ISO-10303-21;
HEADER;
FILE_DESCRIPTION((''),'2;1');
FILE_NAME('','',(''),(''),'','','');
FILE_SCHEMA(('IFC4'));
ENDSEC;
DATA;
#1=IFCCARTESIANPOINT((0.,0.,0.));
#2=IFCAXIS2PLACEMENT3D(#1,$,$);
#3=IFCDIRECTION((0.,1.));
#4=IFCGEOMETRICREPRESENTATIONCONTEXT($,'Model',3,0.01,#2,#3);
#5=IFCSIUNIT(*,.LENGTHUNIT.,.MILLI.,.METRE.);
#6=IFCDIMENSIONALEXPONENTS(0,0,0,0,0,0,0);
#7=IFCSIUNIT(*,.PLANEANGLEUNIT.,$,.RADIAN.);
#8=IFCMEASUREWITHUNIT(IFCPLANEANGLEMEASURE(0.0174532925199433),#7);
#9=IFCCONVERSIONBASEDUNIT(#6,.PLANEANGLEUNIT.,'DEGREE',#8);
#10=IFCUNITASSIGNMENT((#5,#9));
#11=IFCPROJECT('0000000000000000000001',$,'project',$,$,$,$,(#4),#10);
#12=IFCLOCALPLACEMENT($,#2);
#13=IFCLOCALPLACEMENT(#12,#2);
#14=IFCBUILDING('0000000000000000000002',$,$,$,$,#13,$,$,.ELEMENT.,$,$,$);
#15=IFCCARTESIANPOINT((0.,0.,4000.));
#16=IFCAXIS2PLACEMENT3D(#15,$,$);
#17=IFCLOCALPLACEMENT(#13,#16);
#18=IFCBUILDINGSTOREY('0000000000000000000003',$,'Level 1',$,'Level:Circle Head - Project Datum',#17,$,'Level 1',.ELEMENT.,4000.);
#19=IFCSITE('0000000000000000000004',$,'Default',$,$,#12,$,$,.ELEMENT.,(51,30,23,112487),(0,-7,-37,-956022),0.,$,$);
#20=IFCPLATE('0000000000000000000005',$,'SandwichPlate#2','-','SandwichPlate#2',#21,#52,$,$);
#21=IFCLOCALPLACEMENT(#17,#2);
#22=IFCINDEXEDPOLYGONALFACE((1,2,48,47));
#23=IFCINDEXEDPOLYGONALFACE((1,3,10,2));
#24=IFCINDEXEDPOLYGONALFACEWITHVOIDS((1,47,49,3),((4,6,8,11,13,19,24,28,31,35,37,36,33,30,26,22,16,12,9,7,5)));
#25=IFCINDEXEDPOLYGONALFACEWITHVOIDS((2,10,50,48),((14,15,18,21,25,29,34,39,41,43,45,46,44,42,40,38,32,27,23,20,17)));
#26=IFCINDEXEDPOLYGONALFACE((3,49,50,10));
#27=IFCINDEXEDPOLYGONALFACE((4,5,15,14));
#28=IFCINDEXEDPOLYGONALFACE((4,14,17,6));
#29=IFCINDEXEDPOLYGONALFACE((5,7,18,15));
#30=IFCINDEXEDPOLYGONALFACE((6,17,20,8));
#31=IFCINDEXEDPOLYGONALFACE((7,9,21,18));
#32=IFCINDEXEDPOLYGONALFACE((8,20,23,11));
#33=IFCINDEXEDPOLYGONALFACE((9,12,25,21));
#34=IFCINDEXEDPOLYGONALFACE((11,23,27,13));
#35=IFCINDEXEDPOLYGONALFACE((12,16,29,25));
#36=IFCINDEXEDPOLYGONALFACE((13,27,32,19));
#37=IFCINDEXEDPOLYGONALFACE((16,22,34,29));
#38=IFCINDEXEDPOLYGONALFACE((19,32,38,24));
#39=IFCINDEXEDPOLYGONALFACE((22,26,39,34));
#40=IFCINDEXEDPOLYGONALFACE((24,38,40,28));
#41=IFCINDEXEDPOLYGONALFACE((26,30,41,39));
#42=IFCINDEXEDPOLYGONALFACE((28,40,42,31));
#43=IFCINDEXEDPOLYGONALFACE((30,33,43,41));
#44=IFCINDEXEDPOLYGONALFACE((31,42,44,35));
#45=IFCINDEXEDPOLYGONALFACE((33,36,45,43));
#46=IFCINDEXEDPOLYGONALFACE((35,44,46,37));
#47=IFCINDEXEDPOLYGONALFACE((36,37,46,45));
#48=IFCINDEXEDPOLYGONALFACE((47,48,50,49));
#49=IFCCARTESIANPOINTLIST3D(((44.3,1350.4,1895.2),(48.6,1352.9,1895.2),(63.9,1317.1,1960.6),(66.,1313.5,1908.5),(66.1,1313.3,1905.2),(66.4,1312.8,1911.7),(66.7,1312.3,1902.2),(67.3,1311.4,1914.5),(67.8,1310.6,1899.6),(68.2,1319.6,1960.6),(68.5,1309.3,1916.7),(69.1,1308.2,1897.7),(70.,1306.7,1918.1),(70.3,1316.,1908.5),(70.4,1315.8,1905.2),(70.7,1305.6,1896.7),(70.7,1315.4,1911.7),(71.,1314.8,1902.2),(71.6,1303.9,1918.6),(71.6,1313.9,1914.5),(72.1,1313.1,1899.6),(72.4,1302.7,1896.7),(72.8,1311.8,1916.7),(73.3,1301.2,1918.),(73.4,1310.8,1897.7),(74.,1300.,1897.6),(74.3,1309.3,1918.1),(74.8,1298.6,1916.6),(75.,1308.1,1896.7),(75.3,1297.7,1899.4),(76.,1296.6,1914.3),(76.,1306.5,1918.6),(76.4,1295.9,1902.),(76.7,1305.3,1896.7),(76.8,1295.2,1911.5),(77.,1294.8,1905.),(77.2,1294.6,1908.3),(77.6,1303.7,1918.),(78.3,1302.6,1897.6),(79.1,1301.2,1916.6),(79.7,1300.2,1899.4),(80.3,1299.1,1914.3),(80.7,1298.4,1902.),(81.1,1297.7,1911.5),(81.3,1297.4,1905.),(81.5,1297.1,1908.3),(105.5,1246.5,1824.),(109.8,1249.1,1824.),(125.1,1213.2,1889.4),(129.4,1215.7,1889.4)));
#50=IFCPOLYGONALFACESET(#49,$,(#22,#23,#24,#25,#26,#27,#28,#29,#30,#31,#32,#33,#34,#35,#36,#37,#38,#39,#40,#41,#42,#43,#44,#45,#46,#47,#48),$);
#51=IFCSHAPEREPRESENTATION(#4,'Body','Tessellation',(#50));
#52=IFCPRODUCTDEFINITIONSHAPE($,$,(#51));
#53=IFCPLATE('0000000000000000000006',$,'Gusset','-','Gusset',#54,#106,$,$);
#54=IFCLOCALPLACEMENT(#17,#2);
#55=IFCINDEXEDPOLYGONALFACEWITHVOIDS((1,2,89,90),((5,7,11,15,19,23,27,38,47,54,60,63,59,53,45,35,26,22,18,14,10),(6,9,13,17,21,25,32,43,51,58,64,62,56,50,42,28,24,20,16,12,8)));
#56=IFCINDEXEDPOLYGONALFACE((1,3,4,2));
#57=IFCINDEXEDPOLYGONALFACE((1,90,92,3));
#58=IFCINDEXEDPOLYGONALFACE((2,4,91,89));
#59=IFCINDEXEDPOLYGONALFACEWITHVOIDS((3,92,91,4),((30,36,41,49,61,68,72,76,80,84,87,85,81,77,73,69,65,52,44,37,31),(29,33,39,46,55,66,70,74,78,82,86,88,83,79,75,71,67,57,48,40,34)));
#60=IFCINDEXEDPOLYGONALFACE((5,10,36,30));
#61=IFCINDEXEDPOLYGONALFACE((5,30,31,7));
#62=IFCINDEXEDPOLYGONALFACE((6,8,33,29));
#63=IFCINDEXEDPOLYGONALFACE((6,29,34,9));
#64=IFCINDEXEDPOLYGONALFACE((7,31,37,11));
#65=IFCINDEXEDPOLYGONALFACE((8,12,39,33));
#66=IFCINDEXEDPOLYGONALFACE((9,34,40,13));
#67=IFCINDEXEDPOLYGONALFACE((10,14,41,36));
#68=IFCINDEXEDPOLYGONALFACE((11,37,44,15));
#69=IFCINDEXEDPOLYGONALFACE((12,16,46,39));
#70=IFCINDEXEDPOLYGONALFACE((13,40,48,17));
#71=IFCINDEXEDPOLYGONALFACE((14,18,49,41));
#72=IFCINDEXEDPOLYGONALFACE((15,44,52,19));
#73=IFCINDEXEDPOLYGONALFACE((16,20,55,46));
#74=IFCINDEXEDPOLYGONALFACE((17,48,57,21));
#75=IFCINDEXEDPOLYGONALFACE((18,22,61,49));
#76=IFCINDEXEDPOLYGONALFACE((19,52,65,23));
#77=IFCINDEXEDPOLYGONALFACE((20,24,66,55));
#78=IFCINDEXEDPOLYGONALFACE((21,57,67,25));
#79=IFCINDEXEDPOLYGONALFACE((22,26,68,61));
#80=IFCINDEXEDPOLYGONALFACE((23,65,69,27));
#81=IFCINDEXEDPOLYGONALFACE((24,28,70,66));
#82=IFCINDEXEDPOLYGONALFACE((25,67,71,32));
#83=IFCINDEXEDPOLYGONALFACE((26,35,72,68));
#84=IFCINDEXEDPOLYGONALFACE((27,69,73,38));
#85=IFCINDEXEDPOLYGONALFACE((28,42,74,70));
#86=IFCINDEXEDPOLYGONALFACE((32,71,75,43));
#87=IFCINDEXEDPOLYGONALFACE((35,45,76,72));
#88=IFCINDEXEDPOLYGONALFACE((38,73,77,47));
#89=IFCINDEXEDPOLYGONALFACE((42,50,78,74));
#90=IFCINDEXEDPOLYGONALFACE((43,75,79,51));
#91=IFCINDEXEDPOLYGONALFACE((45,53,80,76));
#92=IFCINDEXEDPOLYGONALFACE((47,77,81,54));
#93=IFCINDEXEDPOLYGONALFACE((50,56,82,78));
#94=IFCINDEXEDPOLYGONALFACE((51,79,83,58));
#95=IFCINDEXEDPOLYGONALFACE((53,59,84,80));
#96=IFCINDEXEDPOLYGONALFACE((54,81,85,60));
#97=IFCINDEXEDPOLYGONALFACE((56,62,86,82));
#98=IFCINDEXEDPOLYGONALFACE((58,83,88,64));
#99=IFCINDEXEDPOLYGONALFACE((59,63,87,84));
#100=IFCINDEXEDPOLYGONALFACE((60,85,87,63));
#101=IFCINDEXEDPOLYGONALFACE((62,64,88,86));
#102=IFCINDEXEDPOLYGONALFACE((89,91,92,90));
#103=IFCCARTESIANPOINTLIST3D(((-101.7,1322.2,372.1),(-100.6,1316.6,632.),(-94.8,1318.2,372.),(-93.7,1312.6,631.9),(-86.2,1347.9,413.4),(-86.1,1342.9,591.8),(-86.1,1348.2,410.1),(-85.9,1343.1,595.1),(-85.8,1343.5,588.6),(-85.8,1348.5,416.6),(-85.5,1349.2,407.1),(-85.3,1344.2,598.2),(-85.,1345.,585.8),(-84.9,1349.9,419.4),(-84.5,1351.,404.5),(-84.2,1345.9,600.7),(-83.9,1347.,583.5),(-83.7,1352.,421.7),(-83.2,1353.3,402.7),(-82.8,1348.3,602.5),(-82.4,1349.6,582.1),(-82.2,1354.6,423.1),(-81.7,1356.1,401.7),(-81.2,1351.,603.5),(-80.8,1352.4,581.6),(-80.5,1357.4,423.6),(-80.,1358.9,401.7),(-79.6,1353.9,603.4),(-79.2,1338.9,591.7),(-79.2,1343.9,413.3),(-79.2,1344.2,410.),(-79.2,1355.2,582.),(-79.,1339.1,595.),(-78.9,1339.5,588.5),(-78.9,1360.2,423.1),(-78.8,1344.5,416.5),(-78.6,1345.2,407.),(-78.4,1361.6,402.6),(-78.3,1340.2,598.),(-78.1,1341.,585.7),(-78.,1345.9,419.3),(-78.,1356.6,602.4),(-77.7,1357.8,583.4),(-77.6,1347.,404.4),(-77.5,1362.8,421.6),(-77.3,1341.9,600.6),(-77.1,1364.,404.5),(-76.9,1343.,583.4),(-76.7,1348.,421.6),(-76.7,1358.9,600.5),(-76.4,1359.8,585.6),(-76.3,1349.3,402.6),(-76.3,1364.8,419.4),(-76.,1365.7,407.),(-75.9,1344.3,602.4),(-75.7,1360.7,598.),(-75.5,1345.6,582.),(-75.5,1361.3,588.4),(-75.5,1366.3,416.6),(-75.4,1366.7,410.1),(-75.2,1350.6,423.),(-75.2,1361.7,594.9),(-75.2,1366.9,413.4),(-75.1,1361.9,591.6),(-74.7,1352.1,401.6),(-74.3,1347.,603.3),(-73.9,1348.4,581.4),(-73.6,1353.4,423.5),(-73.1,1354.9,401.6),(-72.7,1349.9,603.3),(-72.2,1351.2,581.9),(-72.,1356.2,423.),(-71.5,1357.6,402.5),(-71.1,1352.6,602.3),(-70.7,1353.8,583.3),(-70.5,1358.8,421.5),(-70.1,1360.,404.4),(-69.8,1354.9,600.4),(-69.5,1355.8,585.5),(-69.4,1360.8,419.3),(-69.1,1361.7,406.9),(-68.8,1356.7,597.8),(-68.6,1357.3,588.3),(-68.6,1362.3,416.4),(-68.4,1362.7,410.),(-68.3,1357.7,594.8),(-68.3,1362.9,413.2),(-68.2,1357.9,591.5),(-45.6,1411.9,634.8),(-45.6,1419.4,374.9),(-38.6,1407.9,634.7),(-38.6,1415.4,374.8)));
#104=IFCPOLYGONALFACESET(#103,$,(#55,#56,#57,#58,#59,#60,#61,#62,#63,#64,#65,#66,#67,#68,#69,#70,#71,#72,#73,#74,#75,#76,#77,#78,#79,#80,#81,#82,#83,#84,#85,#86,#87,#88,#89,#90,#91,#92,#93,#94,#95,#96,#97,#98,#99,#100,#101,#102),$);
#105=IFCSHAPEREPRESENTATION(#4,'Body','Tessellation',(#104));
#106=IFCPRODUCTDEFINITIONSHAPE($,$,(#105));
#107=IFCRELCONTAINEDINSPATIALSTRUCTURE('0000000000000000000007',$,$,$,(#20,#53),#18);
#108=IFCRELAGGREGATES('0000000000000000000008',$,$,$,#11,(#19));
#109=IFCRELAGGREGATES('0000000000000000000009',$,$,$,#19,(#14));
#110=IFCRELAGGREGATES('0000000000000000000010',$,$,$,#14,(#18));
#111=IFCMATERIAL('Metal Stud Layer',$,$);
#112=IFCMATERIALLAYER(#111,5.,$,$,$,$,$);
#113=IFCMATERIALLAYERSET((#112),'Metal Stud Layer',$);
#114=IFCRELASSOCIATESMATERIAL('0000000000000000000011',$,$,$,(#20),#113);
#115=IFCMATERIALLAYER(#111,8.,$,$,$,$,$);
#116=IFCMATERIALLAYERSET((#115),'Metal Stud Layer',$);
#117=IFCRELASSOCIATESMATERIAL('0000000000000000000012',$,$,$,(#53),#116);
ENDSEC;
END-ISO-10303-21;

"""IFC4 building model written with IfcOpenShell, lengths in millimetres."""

from ifc_helpers import new_model, entity, si_unit, converted_unit, direction, frame, origin, origin_with_axes, origin_2d_with_axis, place, context, project, spatial, polyline, circle, outline, extrude, material, layer, layer_set, element, save


model = new_model("IFC4")

# Units and contexts
model_context = context("Model", 3, precision=0.01, world=origin(), true_north=direction((0.0, 1.0)))
ifc_project = project(units=[si_unit("LENGTHUNIT", "METRE", prefix="MILLI"), converted_unit("PLANEANGLEUNIT", "DEGREE", entity("IfcPlaneAngleMeasure", 0.0174532925199433), si_unit("PLANEANGLEUNIT", "RADIAN"), dimensions=[0, 0, 0, 0, 0, 0, 0])], contexts=[model_context])

# Site, building, storey
site_placement = place(None, origin())
site = spatial("IfcSite", under=ifc_project, at=site_placement, Name="Default", CompositionType="ELEMENT", RefLatitude=(51, 30, 23, 112487), RefLongitude=(0, -7, -37, -956022), RefElevation=0.0)
building_placement = place(site_placement, origin())
building = spatial("IfcBuilding", under=site, at=building_placement, CompositionType="ELEMENT")
storey_placement = place(building_placement, frame((0.0, 0.0, 4000.0)))
storey = spatial("IfcBuildingStorey", under=building, at=storey_placement, Name="Level 1", ObjectType="Level:Circle Head - Project Datum", LongName="Level 1", CompositionType="ELEMENT", Elevation=4000.0)

# Shared definitions
ifc_material_1 = material(Name="Metal Stud Layer")
ifc_layer_1 = layer(ifc_material_1, 5.0)
ifc_layer_set_1 = layer_set([ifc_layer_1], Name="Metal Stud Layer")
ifc_layer_2 = layer(ifc_material_1, 8.0)
ifc_layer_set_2 = layer_set([ifc_layer_2], Name="Metal Stud Layer")

# Plate, opening
plate_1_placement = place(storey_placement, frame((68.2, 1319.6, 1960.6), z_axis=(-0.861728, -0.507371, 0.0), x_axis=(-0.258184, 0.438505, -0.860845)))
plate_1 = element("IfcPlate", 1, at=plate_1_placement, inside=storey, material=ifc_layer_set_1, Name="SandwichPlate#2", Description="-", ObjectType="SandwichPlate#2", context=model_context, shape_type="SweptSolid", body=[
    extrude(outline(polyline([(0.0, 0.0), (76.0, 0.0), (76.0, 140.0), (0.0, 140.0), (0.0, 0.0)])), origin_with_axes(), (0.0, 0.0, 1.0), 5.0),
])
opening_1_placement = place(plate_1_placement, frame((38.0, 40.0, -0.5), z_axis=(0.0, 0.0, 1.0), x_axis=(0.0, 1.0, 0.0)))
element("IfcOpeningElement", 2, at=opening_1_placement, cuts=plate_1, ObjectType="Opening", context=model_context, shape_type="SweptSolid", body=[
    extrude(circle(Radius=11.0, at=origin_2d_with_axis()), origin(), (0.0, 0.0, 1.0), 6.0),
])

# Plate, openings
plate_2_placement = place(storey_placement, frame((-39.8, 1405.9, 634.8), z_axis=(-0.865935, 0.499948, 0.014432), x_axis=(0.0, 0.028855, -0.999584)))
plate_2 = element("IfcPlate", 3, at=plate_2_placement, inside=storey, material=ifc_layer_set_2, Name="Gusset", Description="-", ObjectType="Gusset", context=model_context, shape_type="SweptSolid", body=[
    extrude(outline(polyline([(0.2, -2.3), (260.2, -2.3), (260.2, 110.0), (0.2, 107.8), (0.2, -2.3)])), origin_with_axes(), (0.0, 0.0, 1.0), 8.0),
])
opening_2_placement = place(plate_2_placement, frame((40.7, 67.8, 8.5), z_axis=(0.0, 0.0, -1.0), x_axis=(-0.530279, 0.847823, 0.0)))
element("IfcOpeningElement", 4, at=opening_2_placement, cuts=plate_2, ObjectType="Opening", context=model_context, shape_type="SweptSolid", body=[
    extrude(circle(Radius=11.0, at=origin_2d_with_axis()), origin(), (0.0, 0.0, 1.0), 9.0),
])
opening_3_placement = place(plate_2_placement, frame((220.8, 68.0, 8.5), z_axis=(0.0, 0.0, -1.0), x_axis=(0.47613, 0.879375, 0.0)))
element("IfcOpeningElement", 5, at=opening_3_placement, cuts=plate_2, ObjectType="Opening", context=model_context, shape_type="SweptSolid", body=[
    extrude(circle(Radius=11.0, at=origin_2d_with_axis()), origin(), (0.0, 0.0, 1.0), 9.0),
])

save(model, "model.ifc")
